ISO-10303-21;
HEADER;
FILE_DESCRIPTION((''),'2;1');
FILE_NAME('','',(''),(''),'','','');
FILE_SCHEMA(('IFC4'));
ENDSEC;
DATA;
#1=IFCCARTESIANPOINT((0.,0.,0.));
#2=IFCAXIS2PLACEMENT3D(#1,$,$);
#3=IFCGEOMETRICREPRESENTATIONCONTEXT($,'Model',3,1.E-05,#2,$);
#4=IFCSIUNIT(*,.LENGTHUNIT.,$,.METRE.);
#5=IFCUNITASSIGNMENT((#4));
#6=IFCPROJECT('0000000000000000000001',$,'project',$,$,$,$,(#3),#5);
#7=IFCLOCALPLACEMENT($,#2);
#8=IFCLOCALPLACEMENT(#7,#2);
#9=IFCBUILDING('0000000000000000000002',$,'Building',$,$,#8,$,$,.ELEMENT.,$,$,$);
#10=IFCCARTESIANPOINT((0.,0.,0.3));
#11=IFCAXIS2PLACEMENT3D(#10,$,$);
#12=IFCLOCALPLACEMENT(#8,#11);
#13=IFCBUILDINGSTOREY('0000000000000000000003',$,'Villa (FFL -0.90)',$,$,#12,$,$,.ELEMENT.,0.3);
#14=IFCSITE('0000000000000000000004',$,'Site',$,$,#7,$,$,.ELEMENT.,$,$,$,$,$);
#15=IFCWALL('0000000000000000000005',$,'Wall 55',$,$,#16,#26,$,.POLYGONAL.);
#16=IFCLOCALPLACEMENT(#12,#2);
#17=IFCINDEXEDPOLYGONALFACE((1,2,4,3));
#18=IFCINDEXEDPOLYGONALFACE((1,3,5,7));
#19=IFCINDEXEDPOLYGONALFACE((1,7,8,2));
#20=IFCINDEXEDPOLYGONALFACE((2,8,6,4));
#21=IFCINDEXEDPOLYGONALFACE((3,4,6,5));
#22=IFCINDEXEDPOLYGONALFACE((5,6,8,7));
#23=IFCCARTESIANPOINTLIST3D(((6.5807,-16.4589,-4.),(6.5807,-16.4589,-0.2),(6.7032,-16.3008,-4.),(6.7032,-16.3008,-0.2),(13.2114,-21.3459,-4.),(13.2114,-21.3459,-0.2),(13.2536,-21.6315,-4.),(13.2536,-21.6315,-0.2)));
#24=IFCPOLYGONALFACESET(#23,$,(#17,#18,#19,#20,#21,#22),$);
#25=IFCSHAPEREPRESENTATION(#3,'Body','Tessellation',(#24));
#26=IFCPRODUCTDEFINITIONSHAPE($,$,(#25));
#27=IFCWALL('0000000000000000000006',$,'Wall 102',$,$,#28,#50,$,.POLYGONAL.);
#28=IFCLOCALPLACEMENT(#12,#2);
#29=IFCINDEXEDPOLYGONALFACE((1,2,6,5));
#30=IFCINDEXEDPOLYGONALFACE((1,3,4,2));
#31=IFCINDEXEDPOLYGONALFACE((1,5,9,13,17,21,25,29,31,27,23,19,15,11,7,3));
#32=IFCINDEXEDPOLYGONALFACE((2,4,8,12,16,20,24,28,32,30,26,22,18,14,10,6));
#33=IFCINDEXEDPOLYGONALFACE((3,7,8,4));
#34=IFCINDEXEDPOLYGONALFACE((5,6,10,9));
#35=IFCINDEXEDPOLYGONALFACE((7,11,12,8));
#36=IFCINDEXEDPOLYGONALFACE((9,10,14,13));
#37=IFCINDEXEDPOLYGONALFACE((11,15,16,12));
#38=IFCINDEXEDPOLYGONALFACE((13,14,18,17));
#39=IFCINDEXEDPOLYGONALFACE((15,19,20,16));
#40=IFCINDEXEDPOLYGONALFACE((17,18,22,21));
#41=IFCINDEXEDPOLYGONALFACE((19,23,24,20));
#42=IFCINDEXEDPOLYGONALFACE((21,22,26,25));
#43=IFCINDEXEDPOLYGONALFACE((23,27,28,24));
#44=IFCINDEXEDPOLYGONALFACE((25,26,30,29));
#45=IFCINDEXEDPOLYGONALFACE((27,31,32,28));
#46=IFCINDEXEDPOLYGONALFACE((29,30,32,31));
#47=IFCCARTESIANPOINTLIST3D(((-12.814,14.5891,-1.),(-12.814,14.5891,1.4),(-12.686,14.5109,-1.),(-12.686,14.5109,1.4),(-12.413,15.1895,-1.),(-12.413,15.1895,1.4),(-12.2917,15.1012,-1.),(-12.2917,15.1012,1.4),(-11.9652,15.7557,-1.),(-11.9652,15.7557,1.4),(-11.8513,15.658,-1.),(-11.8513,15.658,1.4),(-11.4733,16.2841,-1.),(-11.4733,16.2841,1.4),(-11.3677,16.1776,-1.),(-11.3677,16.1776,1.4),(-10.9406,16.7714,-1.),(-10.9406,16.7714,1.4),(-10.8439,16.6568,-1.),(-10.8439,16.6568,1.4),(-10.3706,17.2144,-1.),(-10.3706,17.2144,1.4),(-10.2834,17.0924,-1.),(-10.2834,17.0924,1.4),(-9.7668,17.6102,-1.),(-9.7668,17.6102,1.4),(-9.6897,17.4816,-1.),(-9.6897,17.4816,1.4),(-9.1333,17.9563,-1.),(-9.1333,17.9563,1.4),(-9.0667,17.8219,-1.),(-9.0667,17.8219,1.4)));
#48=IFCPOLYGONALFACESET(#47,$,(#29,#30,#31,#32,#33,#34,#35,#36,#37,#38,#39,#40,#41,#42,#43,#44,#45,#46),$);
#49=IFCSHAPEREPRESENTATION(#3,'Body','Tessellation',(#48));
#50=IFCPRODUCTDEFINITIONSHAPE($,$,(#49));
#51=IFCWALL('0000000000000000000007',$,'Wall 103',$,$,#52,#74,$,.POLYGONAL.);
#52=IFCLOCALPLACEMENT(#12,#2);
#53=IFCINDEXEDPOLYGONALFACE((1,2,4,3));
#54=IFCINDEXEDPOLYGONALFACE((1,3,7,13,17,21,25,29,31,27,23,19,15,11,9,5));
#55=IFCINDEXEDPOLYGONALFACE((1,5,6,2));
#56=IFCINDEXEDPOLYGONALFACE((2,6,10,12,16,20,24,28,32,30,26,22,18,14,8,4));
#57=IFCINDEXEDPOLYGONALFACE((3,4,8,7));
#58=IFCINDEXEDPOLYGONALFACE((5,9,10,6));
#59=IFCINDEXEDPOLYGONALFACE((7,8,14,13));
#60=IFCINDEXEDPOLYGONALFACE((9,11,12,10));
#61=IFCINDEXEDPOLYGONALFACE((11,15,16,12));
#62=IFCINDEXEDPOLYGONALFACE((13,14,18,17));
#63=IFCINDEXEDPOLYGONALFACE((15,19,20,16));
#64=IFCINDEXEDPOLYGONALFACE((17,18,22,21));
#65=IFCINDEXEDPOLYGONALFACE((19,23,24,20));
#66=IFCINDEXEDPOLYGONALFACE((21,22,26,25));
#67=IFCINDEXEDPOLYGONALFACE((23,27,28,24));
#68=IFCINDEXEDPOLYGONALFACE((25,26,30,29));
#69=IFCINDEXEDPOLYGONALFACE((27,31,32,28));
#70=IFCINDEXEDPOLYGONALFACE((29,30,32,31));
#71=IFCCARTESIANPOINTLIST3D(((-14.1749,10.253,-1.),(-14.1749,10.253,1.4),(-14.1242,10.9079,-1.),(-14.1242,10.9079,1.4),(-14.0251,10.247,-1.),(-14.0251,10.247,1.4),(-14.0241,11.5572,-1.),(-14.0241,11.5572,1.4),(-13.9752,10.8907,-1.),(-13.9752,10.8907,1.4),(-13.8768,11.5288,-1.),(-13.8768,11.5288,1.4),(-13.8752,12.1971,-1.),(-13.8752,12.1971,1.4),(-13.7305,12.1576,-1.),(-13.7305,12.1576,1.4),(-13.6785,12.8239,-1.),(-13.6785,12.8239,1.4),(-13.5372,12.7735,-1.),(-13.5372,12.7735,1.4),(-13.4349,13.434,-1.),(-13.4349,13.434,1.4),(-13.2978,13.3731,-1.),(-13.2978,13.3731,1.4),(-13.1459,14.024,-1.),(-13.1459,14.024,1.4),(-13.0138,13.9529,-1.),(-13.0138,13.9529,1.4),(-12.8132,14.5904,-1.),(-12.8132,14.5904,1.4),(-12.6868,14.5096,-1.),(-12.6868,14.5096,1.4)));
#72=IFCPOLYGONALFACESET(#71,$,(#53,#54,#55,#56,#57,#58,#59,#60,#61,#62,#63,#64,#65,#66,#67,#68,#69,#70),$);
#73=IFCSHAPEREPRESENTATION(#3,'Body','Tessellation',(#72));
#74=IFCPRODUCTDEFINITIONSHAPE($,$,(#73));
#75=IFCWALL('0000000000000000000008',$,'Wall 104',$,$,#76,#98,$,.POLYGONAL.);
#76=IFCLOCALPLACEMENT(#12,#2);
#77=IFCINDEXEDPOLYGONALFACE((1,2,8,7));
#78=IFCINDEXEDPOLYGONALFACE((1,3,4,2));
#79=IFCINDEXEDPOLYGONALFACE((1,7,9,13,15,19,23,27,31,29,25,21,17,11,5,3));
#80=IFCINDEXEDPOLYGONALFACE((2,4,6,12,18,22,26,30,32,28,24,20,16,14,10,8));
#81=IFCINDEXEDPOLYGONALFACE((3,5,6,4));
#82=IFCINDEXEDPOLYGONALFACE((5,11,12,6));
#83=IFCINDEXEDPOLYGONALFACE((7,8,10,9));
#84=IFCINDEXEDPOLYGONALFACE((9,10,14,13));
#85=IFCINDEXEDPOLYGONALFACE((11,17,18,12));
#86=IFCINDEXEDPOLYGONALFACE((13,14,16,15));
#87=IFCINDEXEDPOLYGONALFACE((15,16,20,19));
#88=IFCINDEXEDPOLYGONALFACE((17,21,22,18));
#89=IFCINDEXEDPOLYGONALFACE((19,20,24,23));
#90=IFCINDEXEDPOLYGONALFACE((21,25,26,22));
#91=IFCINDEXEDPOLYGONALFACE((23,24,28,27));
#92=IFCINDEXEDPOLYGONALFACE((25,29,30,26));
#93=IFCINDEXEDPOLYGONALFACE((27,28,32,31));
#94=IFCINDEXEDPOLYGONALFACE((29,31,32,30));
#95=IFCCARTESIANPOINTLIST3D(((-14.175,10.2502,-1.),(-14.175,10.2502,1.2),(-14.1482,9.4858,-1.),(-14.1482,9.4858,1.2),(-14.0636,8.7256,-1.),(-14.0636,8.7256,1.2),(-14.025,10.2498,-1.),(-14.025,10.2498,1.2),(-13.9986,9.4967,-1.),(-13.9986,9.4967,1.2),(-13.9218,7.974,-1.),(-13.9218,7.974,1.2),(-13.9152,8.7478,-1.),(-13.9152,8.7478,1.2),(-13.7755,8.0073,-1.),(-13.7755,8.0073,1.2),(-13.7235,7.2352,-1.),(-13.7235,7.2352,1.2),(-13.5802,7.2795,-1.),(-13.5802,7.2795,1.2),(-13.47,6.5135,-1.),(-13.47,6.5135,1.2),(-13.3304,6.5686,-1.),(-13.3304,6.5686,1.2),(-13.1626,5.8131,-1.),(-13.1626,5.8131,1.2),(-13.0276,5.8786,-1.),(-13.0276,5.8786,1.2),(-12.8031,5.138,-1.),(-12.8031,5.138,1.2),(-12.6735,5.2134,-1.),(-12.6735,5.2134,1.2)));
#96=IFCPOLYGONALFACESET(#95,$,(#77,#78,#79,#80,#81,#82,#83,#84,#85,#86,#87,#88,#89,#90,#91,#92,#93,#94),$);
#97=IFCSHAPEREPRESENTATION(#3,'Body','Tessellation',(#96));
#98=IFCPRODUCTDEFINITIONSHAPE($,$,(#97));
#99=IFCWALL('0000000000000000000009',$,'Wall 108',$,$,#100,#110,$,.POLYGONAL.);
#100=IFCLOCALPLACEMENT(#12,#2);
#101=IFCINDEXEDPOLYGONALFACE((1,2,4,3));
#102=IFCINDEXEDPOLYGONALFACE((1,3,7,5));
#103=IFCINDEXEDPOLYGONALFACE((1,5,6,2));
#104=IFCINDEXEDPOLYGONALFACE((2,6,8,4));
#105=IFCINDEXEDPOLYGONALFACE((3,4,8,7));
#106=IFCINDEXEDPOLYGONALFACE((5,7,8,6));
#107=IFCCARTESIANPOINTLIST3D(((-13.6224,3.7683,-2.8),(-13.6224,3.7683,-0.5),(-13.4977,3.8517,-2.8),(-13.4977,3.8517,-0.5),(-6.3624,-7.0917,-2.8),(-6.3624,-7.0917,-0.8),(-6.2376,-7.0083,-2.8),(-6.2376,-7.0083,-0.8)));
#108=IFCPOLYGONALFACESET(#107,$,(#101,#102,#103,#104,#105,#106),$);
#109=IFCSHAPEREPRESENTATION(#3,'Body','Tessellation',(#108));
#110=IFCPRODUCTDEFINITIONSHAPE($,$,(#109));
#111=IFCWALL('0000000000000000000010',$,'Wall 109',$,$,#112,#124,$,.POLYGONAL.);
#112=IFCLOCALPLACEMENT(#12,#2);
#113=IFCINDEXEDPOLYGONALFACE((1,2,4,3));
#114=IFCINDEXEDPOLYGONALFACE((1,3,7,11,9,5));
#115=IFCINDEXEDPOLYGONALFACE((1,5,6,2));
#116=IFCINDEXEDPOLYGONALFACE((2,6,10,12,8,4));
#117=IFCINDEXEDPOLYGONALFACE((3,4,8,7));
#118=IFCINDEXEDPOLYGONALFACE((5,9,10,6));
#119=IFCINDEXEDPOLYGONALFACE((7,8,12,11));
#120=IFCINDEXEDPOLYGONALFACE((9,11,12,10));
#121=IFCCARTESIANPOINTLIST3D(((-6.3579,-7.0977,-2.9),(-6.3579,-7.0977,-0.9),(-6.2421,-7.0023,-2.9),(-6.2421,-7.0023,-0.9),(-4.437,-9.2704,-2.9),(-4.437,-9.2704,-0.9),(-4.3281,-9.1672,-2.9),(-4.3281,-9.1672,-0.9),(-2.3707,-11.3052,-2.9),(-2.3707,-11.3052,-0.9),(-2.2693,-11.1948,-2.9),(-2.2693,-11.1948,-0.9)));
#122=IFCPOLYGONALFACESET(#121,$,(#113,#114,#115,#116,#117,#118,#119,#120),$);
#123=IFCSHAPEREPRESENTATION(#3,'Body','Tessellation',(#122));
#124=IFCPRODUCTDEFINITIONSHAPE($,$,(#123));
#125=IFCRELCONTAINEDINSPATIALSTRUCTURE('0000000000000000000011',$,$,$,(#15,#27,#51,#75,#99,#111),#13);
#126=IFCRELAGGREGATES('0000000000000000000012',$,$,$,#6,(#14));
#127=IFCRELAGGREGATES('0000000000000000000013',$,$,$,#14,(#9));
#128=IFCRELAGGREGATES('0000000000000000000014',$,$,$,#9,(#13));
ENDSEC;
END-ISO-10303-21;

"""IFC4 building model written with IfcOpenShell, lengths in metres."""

from ifc_helpers import new_model, si_unit, frame, origin, place, context, project, spatial, polyline, outline, extrude, element, save


model = new_model("IFC4")

# Units and contexts
model_context = context("Model", 3, precision=1e-05, world=origin())
ifc_project = project(units=[si_unit("LENGTHUNIT", "METRE")], contexts=[model_context])

# Site, building, storey
site_placement = place(None, origin())
site = spatial("IfcSite", under=ifc_project, at=site_placement, Name="Site", CompositionType="ELEMENT")
building_placement = place(site_placement, origin())
building = spatial("IfcBuilding", under=site, at=building_placement, Name="Building", CompositionType="ELEMENT")
storey_placement = place(building_placement, frame((0.0, 0.0, 0.3)))
storey = spatial("IfcBuildingStorey", under=building, at=storey_placement, Name="Villa (FFL -0.90)", CompositionType="ELEMENT", Elevation=0.3)

# Walls
wall_1_placement = place(storey_placement, frame((0.0, 0.0, -4.0), z_axis=(0.0, 0.0, 1.0), x_axis=(1.0, 0.0, 0.0)))
element("IfcWall", 1, at=wall_1_placement, inside=storey, Name="Wall 55", PredefinedType="POLYGONAL", context=model_context, shape_type="SweptSolid", body=[
    extrude(outline(polyline([(6.7032, -16.3008), (6.5807, -16.4589), (13.2536, -21.6315), (13.2114, -21.3459), (6.7032, -16.3008)])), origin(), (0.0, 0.0, 1.0), 3.8),
])
wall_2_placement = place(storey_placement, frame((0.0, 0.0, -1.0), z_axis=(0.0, 0.0, 1.0), x_axis=(1.0, 0.0, 0.0)))
element("IfcWall", 2, at=wall_2_placement, inside=storey, Name="Wall 102", PredefinedType="POLYGONAL", context=model_context, shape_type="SweptSolid", body=[
    extrude(outline(polyline([(-12.814, 14.5891), (-12.413, 15.1895), (-11.9652, 15.7557), (-11.4733, 16.2841), (-10.9406, 16.7714), (-10.3706, 17.2144), (-9.7668, 17.6102), (-9.1333, 17.9563), (-9.0667, 17.8219), (-9.6897, 17.4816), (-10.2834, 17.0924), (-10.8439, 16.6568), (-11.3677, 16.1776), (-11.8513, 15.658), (-12.2917, 15.1012), (-12.686, 14.5109), (-12.814, 14.5891)])), origin(), (0.0, 0.0, 1.0), 2.4),
])
wall_3_placement = place(storey_placement, frame((0.0, 0.0, -1.0), z_axis=(0.0, 0.0, 1.0), x_axis=(1.0, 0.0, 0.0)))
element("IfcWall", 3, at=wall_3_placement, inside=storey, Name="Wall 103", PredefinedType="POLYGONAL", context=model_context, shape_type="SweptSolid", body=[
    extrude(outline(polyline([(-14.1749, 10.253), (-14.1242, 10.9079), (-14.0241, 11.5572), (-13.8752, 12.1971), (-13.6785, 12.8239), (-13.4349, 13.434), (-13.1459, 14.024), (-12.8132, 14.5904), (-12.6868, 14.5096), (-13.0138, 13.9529), (-13.2978, 13.3731), (-13.5372, 12.7735), (-13.7305, 12.1576), (-13.8768, 11.5288), (-13.9752, 10.8907), (-14.0251, 10.247), (-14.1749, 10.253)])), origin(), (0.0, 0.0, 1.0), 2.4),
])
wall_4_placement = place(storey_placement, frame((0.0, 0.0, -1.0), z_axis=(0.0, 0.0, 1.0), x_axis=(1.0, 0.0, 0.0)))
element("IfcWall", 4, at=wall_4_placement, inside=storey, Name="Wall 104", PredefinedType="POLYGONAL", context=model_context, shape_type="SweptSolid", body=[
    extrude(outline(polyline([(-12.8031, 5.138), (-13.1626, 5.8131), (-13.47, 6.5135), (-13.7235, 7.2352), (-13.9218, 7.974), (-14.0636, 8.7256), (-14.1482, 9.4858), (-14.175, 10.2502), (-14.025, 10.2498), (-13.9985, 9.4967), (-13.9152, 8.7478), (-13.7755, 8.0073), (-13.5802, 7.2795), (-13.3304, 6.5686), (-13.0276, 5.8786), (-12.6735, 5.2134), (-12.8031, 5.138)])), origin(), (0.0, 0.0, 1.0), 2.2),
])
wall_5_placement = place(storey_placement, frame((-6.3, -7.05, -2.8), z_axis=(0.0, 0.0, 1.0), x_axis=(-0.55576, 0.831343, 0.0)))
element("IfcWall", 5, at=wall_5_placement, inside=storey, Name="Wall 108", PredefinedType="POLYGONAL", context=model_context, shape_type="SweptSolid", body=[
    extrude(outline(polyline([(0.0, 0.0), (13.0632, 0.0), (13.0632, 2.3), (0.0, 2.0), (0.0, 0.0)])), frame((0.0, 0.075, 0.0), z_axis=(0.0, -1.0, 0.0), x_axis=(1.0, 0.0, 0.0)), (0.0, 0.0, 1.0), 0.15),
])
wall_6_placement = place(storey_placement, frame((0.0, 0.0, -2.9), z_axis=(0.0, 0.0, 1.0), x_axis=(1.0, 0.0, 0.0)))
element("IfcWall", 6, at=wall_6_placement, inside=storey, Name="Wall 109", PredefinedType="POLYGONAL", context=model_context, shape_type="SweptSolid", body=[
    extrude(outline(polyline([(-2.3707, -11.3052), (-4.437, -9.2704), (-6.3579, -7.0977), (-6.2421, -7.0023), (-4.3281, -9.1672), (-2.2693, -11.1948), (-2.3707, -11.3052)])), origin(), (0.0, 0.0, 1.0), 2.0),
])

save(model, "model.ifc")
